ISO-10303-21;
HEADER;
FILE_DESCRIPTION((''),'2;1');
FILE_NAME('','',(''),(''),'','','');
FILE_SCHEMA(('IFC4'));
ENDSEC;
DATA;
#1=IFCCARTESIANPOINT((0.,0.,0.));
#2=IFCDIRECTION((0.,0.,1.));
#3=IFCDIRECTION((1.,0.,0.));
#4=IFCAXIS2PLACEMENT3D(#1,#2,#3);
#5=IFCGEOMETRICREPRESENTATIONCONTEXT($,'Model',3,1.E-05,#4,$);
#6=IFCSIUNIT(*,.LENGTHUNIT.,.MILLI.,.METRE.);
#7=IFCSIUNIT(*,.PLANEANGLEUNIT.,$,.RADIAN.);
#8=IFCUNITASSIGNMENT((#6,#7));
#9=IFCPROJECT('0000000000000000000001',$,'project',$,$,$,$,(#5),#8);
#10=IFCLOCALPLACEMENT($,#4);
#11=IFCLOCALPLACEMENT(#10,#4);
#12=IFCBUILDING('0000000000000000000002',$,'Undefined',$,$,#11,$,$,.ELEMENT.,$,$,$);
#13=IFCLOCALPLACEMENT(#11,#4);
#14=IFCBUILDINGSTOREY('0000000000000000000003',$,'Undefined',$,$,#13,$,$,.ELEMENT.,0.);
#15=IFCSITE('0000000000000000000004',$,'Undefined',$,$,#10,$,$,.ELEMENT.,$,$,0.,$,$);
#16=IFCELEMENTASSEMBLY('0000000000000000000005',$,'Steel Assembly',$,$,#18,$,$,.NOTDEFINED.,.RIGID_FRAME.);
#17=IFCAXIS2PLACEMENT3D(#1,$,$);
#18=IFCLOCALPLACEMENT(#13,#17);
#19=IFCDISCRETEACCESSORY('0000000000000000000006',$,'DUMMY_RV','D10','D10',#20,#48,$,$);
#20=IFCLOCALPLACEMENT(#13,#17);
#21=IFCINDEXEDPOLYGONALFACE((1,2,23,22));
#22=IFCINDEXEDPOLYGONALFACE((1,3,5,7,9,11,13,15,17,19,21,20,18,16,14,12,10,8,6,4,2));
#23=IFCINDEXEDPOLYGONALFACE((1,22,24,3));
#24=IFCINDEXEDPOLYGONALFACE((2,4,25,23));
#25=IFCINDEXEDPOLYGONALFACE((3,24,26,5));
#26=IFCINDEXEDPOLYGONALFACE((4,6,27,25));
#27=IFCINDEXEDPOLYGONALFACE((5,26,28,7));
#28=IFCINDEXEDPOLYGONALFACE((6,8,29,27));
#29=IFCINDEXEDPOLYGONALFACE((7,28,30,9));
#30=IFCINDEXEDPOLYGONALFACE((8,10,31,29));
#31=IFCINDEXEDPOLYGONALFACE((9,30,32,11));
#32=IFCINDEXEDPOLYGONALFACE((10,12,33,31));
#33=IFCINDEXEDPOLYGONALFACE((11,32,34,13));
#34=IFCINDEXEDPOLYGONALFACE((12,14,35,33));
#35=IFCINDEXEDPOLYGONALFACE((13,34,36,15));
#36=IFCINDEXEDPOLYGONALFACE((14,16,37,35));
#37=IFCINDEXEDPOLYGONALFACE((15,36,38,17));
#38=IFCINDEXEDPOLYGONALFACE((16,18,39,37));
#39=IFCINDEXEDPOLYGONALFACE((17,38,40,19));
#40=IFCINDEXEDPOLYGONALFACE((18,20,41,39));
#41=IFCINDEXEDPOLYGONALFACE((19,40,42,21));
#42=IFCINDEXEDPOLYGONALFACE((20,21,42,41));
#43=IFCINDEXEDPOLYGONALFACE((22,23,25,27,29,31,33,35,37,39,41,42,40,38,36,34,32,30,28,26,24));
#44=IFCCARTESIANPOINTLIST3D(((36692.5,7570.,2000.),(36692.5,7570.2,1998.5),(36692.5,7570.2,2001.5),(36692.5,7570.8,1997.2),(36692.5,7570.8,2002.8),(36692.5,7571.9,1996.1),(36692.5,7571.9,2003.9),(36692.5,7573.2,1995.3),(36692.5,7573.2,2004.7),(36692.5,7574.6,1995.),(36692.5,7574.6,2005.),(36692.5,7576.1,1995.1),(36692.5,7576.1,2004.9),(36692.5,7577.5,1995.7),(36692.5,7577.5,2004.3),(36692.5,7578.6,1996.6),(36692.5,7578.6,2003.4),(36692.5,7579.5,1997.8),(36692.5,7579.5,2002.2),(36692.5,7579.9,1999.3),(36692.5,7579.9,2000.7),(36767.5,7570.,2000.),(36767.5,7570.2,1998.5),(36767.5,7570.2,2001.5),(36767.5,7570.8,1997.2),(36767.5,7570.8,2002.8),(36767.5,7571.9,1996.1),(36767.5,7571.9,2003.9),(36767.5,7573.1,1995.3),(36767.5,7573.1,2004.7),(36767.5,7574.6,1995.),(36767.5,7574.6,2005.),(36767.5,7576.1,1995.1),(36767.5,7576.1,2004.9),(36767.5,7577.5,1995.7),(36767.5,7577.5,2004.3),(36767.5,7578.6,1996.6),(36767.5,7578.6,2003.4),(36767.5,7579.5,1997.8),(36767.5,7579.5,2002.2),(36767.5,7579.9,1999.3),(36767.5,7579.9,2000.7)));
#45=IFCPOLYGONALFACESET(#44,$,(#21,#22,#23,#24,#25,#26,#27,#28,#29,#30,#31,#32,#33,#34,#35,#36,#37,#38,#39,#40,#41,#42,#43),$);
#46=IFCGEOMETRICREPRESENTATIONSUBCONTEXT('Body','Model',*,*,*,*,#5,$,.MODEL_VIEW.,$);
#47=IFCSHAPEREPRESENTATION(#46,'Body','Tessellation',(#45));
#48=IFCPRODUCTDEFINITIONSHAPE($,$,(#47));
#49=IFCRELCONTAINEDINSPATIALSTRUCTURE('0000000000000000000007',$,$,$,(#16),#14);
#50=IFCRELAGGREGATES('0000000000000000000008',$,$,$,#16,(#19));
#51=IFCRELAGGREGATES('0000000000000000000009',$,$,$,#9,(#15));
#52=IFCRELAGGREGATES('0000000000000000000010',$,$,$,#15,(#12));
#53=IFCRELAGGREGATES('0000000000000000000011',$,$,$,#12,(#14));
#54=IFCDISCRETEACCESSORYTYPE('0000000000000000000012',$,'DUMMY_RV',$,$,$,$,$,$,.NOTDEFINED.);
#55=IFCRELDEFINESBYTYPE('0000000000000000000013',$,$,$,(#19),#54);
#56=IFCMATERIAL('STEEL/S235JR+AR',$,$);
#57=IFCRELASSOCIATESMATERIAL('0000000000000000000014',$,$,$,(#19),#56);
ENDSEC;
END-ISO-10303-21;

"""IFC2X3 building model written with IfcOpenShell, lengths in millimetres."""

from ifc_helpers import new_model, si_unit, frame, origin_with_axes, origin_2d_with_axis, place, context, subcontext, project, spatial, circle, extrude, material, type_object, element, aggregate, save


model = new_model("IFC2X3")

# Units and contexts
model_context = context("Model", 3, precision=1e-05, world=origin_with_axes())
body_context = subcontext(model_context, "Body", "Model", "MODEL_VIEW")
ifc_project = project(units=[si_unit("LENGTHUNIT", "METRE", prefix="MILLI"), si_unit("PLANEANGLEUNIT", "RADIAN")], contexts=[model_context])

# Site, building, storey
site_placement = place(None, origin_with_axes())
site = spatial("IfcSite", under=ifc_project, at=site_placement, Name="Undefined", CompositionType="ELEMENT", RefElevation=0.0)
building_placement = place(site_placement, origin_with_axes())
building = spatial("IfcBuilding", under=site, at=building_placement, Name="Undefined", CompositionType="ELEMENT")
storey_placement = place(building_placement, origin_with_axes())
storey = spatial("IfcBuildingStorey", under=building, at=storey_placement, Name="Undefined", CompositionType="ELEMENT", Elevation=0.0)

# Element assembly
ifc_material_1 = material(Name="STEEL/S235JR+AR")
assembly_1_placement = place(storey_placement, origin_with_axes())
assembly_1 = element("IfcElementAssembly", 1, at=assembly_1_placement, inside=storey, Name="Steel Assembly", AssemblyPlace="NOTDEFINED", PredefinedType="RIGID_FRAME")

# Discrete accessory
discrete_accessory_type = type_object("IfcDiscreteAccessoryType", Name="DUMMY_RV")
discrete_accessory_1_placement = place(assembly_1_placement, frame((36692.5, 7575.0, 2000.0), z_axis=(0.0, 0.0, 1.0), x_axis=(1.0, -0.00003, 0.0)))
discrete_accessory_1 = element("IfcDiscreteAccessory", 2, at=discrete_accessory_1_placement, type_object=discrete_accessory_type, material=ifc_material_1, Name="DUMMY_RV", Description="D10", ObjectType="D10", context=body_context, shape_type="SweptSolid", body=[
    extrude(circle(Radius=5.0, at=origin_2d_with_axis()), frame((75.0, 0.0, 0.0), z_axis=(-1.0, 0.0, 0.0), x_axis=(0.0, -1.0, 0.0)), (0.0, 0.0, 1.0), 75.0),
])
aggregate(assembly_1, [discrete_accessory_1])

save(model, "model.ifc")
